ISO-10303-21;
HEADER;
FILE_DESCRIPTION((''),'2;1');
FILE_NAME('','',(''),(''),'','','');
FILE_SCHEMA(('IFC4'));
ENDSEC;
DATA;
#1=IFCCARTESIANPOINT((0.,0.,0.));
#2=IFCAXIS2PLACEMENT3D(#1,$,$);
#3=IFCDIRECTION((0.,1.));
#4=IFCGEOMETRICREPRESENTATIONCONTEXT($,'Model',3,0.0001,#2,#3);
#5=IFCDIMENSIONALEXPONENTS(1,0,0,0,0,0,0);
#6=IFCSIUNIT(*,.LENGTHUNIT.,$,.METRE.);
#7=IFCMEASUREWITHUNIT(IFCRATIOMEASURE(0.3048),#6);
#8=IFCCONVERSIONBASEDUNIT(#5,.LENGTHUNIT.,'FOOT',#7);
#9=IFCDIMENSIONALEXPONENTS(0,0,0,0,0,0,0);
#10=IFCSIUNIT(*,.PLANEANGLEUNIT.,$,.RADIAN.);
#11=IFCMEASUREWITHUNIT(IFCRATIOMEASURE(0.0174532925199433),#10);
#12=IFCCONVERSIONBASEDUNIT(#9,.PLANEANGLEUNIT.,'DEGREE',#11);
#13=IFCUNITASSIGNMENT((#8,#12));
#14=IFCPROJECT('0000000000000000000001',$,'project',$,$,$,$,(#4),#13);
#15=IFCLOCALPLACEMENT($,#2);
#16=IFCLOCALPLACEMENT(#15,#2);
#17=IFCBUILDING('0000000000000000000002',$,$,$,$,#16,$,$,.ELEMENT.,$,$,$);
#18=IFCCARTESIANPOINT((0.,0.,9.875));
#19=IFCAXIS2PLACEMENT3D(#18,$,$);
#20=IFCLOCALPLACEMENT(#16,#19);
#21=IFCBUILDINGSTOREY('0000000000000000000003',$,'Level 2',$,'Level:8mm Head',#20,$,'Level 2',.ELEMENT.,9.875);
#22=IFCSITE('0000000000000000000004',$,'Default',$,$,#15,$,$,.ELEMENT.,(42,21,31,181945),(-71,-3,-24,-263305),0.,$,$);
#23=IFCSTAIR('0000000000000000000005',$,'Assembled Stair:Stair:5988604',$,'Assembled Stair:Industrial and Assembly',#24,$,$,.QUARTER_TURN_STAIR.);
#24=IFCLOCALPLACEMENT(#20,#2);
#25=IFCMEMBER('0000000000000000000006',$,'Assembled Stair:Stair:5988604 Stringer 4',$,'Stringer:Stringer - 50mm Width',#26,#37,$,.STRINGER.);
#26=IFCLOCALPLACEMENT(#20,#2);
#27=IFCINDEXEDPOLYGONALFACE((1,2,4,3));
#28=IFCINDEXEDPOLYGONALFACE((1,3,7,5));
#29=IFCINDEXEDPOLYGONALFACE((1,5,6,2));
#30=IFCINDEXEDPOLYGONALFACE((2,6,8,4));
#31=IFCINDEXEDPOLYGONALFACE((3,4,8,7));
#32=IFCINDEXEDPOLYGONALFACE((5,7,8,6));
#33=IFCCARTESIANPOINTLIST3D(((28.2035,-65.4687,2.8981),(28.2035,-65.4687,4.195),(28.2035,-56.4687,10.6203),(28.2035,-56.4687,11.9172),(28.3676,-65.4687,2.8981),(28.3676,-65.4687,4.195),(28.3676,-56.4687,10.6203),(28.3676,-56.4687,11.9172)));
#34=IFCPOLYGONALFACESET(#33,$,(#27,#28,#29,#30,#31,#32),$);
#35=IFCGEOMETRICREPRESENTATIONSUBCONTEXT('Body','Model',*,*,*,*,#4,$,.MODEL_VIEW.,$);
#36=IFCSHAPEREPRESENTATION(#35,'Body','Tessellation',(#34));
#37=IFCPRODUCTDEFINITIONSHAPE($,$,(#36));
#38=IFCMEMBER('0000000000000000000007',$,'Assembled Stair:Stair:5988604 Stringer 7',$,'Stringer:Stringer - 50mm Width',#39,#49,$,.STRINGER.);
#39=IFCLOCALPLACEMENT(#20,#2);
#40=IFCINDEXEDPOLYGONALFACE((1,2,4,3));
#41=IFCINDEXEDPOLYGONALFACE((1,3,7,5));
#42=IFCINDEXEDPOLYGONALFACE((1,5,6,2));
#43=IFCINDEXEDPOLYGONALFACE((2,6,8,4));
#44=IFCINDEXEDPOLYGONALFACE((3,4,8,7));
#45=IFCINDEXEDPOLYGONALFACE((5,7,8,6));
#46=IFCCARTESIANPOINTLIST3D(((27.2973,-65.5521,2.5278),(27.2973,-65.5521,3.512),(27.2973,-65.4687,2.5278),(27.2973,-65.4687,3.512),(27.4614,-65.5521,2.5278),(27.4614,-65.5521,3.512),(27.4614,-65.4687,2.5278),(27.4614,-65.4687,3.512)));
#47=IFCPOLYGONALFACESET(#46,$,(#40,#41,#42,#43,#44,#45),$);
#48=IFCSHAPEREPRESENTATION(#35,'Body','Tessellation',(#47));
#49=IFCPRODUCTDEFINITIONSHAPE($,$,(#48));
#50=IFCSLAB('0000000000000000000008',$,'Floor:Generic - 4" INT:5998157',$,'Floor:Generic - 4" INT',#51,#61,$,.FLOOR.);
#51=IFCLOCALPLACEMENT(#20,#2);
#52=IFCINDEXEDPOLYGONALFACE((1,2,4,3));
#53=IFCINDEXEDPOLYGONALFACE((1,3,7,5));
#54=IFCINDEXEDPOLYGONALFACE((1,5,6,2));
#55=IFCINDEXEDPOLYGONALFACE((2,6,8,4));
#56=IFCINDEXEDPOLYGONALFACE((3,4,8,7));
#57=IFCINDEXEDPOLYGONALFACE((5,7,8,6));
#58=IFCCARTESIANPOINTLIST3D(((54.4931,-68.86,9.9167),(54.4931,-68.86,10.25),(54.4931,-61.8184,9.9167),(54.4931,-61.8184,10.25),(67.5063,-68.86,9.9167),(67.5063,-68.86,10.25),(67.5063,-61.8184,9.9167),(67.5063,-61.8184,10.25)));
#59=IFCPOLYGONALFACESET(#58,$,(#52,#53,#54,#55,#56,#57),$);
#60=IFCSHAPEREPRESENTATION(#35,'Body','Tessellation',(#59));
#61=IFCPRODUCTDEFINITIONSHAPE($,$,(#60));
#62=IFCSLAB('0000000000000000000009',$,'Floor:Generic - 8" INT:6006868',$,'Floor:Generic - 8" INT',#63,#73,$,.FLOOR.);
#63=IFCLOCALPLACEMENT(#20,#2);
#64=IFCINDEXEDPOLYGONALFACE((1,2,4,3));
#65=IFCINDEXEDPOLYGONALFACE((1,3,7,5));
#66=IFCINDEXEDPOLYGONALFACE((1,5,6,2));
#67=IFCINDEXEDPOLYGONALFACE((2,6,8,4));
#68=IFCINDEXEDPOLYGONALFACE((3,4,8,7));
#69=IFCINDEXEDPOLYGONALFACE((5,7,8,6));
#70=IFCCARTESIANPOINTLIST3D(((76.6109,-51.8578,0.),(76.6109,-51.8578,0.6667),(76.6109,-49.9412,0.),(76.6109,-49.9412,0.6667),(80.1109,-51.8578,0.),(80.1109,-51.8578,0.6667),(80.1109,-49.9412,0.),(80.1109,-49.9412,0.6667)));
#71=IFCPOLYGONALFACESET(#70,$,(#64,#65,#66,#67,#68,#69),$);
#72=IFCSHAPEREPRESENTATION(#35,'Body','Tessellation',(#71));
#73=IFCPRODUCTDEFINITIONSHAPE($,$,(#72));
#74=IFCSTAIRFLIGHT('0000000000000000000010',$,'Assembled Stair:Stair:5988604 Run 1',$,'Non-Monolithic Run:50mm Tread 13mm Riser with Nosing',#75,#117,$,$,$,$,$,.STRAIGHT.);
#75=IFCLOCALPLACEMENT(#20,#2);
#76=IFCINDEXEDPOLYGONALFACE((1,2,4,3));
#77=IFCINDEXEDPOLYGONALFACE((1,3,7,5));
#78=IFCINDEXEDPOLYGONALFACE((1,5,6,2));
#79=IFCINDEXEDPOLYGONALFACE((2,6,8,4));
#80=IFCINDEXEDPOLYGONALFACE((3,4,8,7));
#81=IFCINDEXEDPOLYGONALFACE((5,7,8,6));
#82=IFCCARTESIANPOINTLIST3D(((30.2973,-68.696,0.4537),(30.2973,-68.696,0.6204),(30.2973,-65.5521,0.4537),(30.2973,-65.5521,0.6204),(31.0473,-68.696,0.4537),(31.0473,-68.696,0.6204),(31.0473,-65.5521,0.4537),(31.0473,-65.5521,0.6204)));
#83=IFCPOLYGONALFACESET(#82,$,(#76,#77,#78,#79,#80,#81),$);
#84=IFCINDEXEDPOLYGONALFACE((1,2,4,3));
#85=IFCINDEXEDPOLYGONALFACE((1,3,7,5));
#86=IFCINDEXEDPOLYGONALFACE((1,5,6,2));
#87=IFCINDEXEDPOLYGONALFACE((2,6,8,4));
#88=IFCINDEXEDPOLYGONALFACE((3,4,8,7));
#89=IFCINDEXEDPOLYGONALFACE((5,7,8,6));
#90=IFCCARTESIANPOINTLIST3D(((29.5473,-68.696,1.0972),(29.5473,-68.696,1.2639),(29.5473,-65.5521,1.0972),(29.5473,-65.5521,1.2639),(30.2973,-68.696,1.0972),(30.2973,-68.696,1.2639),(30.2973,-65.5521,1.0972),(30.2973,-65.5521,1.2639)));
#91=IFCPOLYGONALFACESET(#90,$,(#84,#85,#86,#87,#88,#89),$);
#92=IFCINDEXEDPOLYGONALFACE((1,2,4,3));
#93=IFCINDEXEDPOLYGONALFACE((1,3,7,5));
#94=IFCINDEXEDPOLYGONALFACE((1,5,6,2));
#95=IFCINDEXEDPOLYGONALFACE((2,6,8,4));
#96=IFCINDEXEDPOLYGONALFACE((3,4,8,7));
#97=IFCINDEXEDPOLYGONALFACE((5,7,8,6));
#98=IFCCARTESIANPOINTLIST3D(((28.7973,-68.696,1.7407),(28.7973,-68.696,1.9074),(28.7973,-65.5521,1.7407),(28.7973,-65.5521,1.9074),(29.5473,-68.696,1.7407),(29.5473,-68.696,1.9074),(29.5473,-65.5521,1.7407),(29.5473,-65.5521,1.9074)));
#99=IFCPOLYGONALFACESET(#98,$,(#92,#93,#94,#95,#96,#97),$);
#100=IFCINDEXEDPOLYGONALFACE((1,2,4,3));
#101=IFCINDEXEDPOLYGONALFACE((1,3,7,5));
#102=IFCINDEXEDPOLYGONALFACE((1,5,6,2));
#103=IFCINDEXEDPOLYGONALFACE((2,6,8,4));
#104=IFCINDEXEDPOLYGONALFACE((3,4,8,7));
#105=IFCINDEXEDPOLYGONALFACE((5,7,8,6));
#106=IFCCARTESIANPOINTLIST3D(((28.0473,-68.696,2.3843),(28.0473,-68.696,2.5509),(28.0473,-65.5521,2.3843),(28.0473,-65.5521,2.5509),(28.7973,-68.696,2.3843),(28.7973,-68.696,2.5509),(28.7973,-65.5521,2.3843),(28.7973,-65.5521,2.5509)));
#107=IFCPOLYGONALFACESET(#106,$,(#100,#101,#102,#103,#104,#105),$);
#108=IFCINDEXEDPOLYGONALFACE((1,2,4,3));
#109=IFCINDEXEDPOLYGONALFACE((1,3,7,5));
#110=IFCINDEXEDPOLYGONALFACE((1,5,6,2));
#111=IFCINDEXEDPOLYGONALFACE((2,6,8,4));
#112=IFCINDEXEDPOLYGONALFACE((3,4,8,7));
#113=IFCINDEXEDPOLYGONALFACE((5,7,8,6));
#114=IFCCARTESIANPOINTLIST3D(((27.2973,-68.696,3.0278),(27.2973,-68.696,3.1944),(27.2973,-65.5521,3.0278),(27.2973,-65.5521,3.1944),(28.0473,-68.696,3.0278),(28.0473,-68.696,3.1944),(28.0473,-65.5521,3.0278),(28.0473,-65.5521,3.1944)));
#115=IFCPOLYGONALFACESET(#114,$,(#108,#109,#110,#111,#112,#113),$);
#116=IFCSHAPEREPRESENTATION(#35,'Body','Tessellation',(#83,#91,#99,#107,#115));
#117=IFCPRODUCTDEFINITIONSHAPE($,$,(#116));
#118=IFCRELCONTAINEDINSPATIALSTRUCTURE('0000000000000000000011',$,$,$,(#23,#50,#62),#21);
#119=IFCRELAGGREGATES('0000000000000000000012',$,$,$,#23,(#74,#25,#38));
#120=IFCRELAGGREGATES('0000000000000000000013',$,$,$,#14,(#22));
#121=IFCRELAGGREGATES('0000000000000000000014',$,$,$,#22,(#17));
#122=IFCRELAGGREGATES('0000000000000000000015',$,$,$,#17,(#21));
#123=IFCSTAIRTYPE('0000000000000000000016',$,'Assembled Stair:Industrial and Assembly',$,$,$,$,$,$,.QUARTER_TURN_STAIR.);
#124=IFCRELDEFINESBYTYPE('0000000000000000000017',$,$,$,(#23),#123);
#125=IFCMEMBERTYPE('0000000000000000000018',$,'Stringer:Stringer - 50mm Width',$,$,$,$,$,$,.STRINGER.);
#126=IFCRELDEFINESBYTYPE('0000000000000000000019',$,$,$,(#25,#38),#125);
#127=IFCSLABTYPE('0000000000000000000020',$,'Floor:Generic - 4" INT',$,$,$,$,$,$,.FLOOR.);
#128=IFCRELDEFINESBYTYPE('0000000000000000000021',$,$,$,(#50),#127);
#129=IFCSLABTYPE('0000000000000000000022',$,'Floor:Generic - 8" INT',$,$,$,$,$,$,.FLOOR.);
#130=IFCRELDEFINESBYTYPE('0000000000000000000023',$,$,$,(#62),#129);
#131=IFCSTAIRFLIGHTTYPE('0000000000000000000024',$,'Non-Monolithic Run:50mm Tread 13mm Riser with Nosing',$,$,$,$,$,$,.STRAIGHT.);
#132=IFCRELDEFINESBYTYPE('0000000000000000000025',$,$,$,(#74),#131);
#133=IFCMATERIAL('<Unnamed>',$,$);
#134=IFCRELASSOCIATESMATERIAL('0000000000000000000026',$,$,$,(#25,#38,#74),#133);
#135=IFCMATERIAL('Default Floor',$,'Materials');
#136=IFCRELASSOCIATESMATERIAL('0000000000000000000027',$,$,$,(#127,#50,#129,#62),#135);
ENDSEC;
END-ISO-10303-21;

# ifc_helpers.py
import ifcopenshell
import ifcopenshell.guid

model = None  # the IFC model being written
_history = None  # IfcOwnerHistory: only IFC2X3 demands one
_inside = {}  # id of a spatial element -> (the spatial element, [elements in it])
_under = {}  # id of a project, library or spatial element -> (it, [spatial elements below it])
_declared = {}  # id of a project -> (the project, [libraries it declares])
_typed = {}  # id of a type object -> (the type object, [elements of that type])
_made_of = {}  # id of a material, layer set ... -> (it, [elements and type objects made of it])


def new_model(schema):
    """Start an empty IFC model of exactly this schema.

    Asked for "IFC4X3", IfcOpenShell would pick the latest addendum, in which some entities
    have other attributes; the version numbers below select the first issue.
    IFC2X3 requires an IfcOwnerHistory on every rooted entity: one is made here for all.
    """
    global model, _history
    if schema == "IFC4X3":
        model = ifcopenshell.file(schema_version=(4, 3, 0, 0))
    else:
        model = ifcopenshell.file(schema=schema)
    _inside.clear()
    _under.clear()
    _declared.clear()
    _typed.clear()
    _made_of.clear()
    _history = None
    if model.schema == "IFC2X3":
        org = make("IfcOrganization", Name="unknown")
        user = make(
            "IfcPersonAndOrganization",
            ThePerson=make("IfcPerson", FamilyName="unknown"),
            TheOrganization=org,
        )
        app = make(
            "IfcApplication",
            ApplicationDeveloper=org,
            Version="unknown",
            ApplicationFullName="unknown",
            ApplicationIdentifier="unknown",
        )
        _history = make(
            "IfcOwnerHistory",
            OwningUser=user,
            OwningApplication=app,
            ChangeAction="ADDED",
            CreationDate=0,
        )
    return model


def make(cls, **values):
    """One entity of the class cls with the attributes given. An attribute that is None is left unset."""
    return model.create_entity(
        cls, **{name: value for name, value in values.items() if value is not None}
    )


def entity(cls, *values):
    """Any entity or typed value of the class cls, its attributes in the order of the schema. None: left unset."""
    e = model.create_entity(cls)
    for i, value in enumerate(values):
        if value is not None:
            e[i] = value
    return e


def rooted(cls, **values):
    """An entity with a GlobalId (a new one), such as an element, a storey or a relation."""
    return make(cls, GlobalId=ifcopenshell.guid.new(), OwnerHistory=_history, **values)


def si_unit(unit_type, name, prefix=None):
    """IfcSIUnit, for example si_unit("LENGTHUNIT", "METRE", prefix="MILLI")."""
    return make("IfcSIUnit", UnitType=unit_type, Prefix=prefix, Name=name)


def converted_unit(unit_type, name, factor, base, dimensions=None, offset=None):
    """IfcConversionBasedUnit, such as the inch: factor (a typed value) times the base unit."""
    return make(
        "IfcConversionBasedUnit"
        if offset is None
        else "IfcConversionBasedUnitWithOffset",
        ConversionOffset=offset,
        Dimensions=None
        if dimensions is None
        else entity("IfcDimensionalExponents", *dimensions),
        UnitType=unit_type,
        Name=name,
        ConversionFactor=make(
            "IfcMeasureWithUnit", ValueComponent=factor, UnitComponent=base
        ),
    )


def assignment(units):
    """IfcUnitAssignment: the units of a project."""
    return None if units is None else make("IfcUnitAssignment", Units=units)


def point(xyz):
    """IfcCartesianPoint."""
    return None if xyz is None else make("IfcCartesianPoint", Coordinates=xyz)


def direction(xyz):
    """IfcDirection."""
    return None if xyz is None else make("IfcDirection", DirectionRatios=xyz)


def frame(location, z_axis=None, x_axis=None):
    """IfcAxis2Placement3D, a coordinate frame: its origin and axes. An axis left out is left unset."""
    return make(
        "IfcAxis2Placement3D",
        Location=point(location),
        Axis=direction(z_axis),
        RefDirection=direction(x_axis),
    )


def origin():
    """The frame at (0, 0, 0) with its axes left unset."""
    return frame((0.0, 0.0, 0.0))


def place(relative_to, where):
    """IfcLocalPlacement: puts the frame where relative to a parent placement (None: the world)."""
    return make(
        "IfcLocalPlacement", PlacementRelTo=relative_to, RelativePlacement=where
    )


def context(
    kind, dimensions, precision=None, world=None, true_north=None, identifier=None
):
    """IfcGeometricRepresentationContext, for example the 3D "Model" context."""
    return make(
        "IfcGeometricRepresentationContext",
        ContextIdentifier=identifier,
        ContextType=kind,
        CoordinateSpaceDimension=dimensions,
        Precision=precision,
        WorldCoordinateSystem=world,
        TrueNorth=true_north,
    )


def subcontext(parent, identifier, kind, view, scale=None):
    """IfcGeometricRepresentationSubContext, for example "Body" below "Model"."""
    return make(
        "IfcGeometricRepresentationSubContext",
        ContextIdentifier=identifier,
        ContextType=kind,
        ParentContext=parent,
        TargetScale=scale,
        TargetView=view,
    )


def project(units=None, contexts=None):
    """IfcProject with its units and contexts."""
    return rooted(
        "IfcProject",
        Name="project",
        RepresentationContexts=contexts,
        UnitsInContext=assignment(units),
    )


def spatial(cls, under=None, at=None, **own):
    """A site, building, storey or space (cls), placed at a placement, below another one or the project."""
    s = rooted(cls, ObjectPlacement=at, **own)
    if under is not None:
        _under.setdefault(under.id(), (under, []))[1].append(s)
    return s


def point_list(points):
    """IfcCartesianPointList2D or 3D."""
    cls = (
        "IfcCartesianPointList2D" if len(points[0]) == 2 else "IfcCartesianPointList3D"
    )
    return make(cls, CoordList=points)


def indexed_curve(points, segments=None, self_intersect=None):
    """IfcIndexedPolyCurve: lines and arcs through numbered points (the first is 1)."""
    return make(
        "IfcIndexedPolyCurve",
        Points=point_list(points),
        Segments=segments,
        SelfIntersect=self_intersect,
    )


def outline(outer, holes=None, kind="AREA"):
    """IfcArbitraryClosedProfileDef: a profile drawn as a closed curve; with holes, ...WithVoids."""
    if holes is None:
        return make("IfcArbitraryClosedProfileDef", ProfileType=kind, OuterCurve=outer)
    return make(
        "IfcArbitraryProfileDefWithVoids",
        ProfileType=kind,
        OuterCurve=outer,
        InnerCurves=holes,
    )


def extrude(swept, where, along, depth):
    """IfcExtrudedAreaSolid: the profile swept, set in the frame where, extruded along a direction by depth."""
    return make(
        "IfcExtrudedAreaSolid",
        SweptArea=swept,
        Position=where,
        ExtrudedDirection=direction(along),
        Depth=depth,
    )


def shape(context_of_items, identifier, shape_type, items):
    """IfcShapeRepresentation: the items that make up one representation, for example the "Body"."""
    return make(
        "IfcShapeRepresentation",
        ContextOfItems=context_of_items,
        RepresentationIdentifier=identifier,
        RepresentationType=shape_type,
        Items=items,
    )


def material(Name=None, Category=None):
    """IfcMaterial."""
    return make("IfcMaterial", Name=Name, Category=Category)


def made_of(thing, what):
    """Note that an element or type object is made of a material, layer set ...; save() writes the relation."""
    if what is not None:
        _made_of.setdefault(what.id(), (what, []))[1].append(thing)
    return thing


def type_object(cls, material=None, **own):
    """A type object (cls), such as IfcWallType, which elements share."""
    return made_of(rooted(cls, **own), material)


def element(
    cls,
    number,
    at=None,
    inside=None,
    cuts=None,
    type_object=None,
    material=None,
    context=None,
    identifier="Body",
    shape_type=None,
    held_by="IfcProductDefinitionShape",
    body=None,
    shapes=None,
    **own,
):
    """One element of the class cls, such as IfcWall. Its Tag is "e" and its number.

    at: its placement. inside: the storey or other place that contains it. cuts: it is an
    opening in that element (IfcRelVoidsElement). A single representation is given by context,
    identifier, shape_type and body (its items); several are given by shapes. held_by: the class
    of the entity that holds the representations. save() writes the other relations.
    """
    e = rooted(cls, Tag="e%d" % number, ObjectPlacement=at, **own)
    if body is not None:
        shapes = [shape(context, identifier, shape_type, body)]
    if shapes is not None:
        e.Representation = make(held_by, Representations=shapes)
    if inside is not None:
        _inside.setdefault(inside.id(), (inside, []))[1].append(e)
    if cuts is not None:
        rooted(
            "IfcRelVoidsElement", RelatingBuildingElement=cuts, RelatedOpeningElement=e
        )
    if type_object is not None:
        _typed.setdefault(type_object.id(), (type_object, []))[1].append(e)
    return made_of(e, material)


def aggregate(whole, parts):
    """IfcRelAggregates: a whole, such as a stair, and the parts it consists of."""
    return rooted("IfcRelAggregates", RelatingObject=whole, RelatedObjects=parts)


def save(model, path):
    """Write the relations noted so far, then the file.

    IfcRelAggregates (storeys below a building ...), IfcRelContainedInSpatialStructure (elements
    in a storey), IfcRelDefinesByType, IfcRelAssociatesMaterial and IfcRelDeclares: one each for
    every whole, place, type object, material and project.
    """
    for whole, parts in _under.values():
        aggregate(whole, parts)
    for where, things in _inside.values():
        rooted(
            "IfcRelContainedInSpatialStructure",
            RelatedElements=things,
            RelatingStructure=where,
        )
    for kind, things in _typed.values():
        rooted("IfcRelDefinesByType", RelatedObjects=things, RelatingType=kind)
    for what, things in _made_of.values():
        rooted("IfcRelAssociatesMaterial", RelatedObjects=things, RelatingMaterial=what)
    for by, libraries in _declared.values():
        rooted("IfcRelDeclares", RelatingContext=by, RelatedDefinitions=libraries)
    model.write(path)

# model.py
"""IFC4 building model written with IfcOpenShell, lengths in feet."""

from ifc_helpers import new_model, entity, si_unit, converted_unit, direction, frame, origin, place, context, subcontext, project, spatial, indexed_curve, outline, extrude, material, type_object, element, aggregate, save


model = new_model("IFC4")

# Units and contexts
model_context = context("Model", 3, precision=0.0001, world=origin(), true_north=direction((0.0, 1.0)))
body_context = subcontext(model_context, "Body", "Model", "MODEL_VIEW")
ifc_project = project(units=[converted_unit("LENGTHUNIT", "FOOT", entity("IfcRatioMeasure", 0.3048), si_unit("LENGTHUNIT", "METRE"), dimensions=[1, 0, 0, 0, 0, 0, 0]), converted_unit("PLANEANGLEUNIT", "DEGREE", entity("IfcRatioMeasure", 0.0174532925199433), si_unit("PLANEANGLEUNIT", "RADIAN"), dimensions=[0, 0, 0, 0, 0, 0, 0])], contexts=[model_context])

# Site, building, storey
site_placement = place(None, origin())
site = spatial("IfcSite", under=ifc_project, at=site_placement, Name="Default", CompositionType="ELEMENT", RefLatitude=(42, 21, 31, 181945), RefLongitude=(-71, -3, -24, -263305), RefElevation=0.0)
building_placement = place(site_placement, origin())
building = spatial("IfcBuilding", under=site, at=building_placement, CompositionType="ELEMENT")
storey_placement = place(building_placement, frame((0.0, 0.0, 9.875)))
storey = spatial("IfcBuildingStorey", under=building, at=storey_placement, Name="Level 2", ObjectType="Level:8mm Head", LongName="Level 2", CompositionType="ELEMENT", Elevation=9.875)

# Stair, members
stair_type = type_object("IfcStairType", Name="Assembled Stair:Industrial and Assembly", PredefinedType="QUARTER_TURN_STAIR")
stair_placement = place(storey_placement, origin())
stair = element("IfcStair", 1, at=stair_placement, inside=storey, type_object=stair_type, Name="Assembled Stair:Stair:5988604", ObjectType="Assembled Stair:Industrial and Assembly", PredefinedType="QUARTER_TURN_STAIR")
ifc_material_1 = material(Name="<Unnamed>")
member_type = type_object("IfcMemberType", Name="Stringer:Stringer - 50mm Width", PredefinedType="STRINGER")
member_1_placement = place(stair_placement, origin())
member_1 = element("IfcMember", 2, at=member_1_placement, type_object=member_type, material=ifc_material_1, Name="Assembled Stair:Stair:5988604 Stringer 4", ObjectType="Stringer:Stringer - 50mm Width", PredefinedType="STRINGER", context=body_context, shape_type="SweptSolid", body=[
    extrude(outline(indexed_curve([(-6.3517, -0.4921), (5.5072, -0.4921), (6.3517, 0.4921), (-5.5072, 0.4921), (-6.3517, -0.4921)], self_intersect=False)), frame((28.2035, -60.9687, 7.4076), z_axis=(1.0, 0.0, 0.0), x_axis=(0.0, 0.758926, 0.651177)), (0.0, 0.0, 1.0), 0.164),
])
member_2_placement = place(stair_placement, origin())
member_2 = element("IfcMember", 3, at=member_2_placement, type_object=member_type, material=ifc_material_1, Name="Assembled Stair:Stair:5988604 Stringer 7", ObjectType="Stringer:Stringer - 50mm Width", PredefinedType="STRINGER", context=body_context, shape_type="SweptSolid", body=[
    extrude(outline(indexed_curve([(-0.0417, -0.082), (0.0417, -0.082), (0.0417, 0.082), (-0.0417, 0.082), (-0.0417, -0.082)], self_intersect=False)), frame((27.3794, -65.5104, 2.5278), z_axis=(0.0, 0.0, 1.0), x_axis=(0.0, 1.0, 0.0)), (0.0, 0.0, 1.0), 0.9843),
])

# Slabs
ifc_material_2 = material(Name="Default Floor", Category="Materials")
slab_type_1 = type_object("IfcSlabType", Name="Floor:Generic - 4\" INT", PredefinedType="FLOOR", material=ifc_material_2)
slab_1_placement = place(storey_placement, origin())
element("IfcSlab", 4, at=slab_1_placement, inside=storey, type_object=slab_type_1, material=ifc_material_2, Name="Floor:Generic - 4\" INT:5998157", ObjectType="Floor:Generic - 4\" INT", PredefinedType="FLOOR", context=body_context, shape_type="SweptSolid", body=[
    extrude(outline(indexed_curve([(-3.5208, -6.5066), (3.5208, -6.5066), (3.5208, 6.5066), (-3.5208, 6.5066), (-3.5208, -6.5066)], self_intersect=False)), frame((60.9997, -65.3392, 10.25), z_axis=(0.0, 0.0, -1.0), x_axis=(0.0, 1.0, 0.0)), (0.0, 0.0, 1.0), 0.3333),
])
slab_type_2 = type_object("IfcSlabType", Name="Floor:Generic - 8\" INT", PredefinedType="FLOOR", material=ifc_material_2)
slab_2_placement = place(storey_placement, origin())
element("IfcSlab", 5, at=slab_2_placement, inside=storey, type_object=slab_type_2, material=ifc_material_2, Name="Floor:Generic - 8\" INT:6006868", ObjectType="Floor:Generic - 8\" INT", PredefinedType="FLOOR", context=body_context, shape_type="SweptSolid", body=[
    extrude(outline(indexed_curve([(-0.9583, -1.75), (0.9583, -1.75), (0.9583, 1.75), (-0.9583, 1.75), (-0.9583, -1.75)], self_intersect=False)), frame((78.3609, -50.8995, 0.6667), z_axis=(0.0, 0.0, -1.0), x_axis=(0.0, 1.0, 0.0)), (0.0, 0.0, 1.0), 0.6667),
])

# Stair flight
stair_flight_type_1 = type_object("IfcStairFlightType", Name="Non-Monolithic Run:50mm Tread 13mm Riser with Nosing", PredefinedType="STRAIGHT")
stair_flight_1_placement = place(stair_placement, origin())
stair_flight_1 = element("IfcStairFlight", 6, at=stair_flight_1_placement, type_object=stair_flight_type_1, material=ifc_material_1, Name="Assembled Stair:Stair:5988604 Run 1", ObjectType="Non-Monolithic Run:50mm Tread 13mm Riser with Nosing", PredefinedType="STRAIGHT", context=body_context, shape_type="SweptSolid", body=[
    extrude(outline(indexed_curve([(-0.375, -1.572), (0.375, -1.572), (0.375, 1.572), (-0.375, 1.572), (-0.375, -1.572)], self_intersect=False)), frame((30.6723, -67.124, 0.4537)), (0.0, 0.0, 1.0), 0.1667),
    extrude(outline(indexed_curve([(-0.375, -1.572), (0.375, -1.572), (0.375, 1.572), (-0.375, 1.572), (-0.375, -1.572)], self_intersect=False)), frame((29.9223, -67.124, 1.0972)), (0.0, 0.0, 1.0), 0.1667),
    extrude(outline(indexed_curve([(-0.375, -1.572), (0.375, -1.572), (0.375, 1.572), (-0.375, 1.572), (-0.375, -1.572)], self_intersect=False)), frame((29.1723, -67.124, 1.7407)), (0.0, 0.0, 1.0), 0.1667),
    extrude(outline(indexed_curve([(-0.375, -1.572), (0.375, -1.572), (0.375, 1.572), (-0.375, 1.572), (-0.375, -1.572)], self_intersect=False)), frame((28.4223, -67.124, 2.3843)), (0.0, 0.0, 1.0), 0.1667),
    extrude(outline(indexed_curve([(-0.375, -1.572), (0.375, -1.572), (0.375, 1.572), (-0.375, 1.572), (-0.375, -1.572)], self_intersect=False)), frame((27.6723, -67.124, 3.0278)), (0.0, 0.0, 1.0), 0.1667),
])
aggregate(stair, [stair_flight_1, member_1, member_2])

save(model, "model.ifc")
